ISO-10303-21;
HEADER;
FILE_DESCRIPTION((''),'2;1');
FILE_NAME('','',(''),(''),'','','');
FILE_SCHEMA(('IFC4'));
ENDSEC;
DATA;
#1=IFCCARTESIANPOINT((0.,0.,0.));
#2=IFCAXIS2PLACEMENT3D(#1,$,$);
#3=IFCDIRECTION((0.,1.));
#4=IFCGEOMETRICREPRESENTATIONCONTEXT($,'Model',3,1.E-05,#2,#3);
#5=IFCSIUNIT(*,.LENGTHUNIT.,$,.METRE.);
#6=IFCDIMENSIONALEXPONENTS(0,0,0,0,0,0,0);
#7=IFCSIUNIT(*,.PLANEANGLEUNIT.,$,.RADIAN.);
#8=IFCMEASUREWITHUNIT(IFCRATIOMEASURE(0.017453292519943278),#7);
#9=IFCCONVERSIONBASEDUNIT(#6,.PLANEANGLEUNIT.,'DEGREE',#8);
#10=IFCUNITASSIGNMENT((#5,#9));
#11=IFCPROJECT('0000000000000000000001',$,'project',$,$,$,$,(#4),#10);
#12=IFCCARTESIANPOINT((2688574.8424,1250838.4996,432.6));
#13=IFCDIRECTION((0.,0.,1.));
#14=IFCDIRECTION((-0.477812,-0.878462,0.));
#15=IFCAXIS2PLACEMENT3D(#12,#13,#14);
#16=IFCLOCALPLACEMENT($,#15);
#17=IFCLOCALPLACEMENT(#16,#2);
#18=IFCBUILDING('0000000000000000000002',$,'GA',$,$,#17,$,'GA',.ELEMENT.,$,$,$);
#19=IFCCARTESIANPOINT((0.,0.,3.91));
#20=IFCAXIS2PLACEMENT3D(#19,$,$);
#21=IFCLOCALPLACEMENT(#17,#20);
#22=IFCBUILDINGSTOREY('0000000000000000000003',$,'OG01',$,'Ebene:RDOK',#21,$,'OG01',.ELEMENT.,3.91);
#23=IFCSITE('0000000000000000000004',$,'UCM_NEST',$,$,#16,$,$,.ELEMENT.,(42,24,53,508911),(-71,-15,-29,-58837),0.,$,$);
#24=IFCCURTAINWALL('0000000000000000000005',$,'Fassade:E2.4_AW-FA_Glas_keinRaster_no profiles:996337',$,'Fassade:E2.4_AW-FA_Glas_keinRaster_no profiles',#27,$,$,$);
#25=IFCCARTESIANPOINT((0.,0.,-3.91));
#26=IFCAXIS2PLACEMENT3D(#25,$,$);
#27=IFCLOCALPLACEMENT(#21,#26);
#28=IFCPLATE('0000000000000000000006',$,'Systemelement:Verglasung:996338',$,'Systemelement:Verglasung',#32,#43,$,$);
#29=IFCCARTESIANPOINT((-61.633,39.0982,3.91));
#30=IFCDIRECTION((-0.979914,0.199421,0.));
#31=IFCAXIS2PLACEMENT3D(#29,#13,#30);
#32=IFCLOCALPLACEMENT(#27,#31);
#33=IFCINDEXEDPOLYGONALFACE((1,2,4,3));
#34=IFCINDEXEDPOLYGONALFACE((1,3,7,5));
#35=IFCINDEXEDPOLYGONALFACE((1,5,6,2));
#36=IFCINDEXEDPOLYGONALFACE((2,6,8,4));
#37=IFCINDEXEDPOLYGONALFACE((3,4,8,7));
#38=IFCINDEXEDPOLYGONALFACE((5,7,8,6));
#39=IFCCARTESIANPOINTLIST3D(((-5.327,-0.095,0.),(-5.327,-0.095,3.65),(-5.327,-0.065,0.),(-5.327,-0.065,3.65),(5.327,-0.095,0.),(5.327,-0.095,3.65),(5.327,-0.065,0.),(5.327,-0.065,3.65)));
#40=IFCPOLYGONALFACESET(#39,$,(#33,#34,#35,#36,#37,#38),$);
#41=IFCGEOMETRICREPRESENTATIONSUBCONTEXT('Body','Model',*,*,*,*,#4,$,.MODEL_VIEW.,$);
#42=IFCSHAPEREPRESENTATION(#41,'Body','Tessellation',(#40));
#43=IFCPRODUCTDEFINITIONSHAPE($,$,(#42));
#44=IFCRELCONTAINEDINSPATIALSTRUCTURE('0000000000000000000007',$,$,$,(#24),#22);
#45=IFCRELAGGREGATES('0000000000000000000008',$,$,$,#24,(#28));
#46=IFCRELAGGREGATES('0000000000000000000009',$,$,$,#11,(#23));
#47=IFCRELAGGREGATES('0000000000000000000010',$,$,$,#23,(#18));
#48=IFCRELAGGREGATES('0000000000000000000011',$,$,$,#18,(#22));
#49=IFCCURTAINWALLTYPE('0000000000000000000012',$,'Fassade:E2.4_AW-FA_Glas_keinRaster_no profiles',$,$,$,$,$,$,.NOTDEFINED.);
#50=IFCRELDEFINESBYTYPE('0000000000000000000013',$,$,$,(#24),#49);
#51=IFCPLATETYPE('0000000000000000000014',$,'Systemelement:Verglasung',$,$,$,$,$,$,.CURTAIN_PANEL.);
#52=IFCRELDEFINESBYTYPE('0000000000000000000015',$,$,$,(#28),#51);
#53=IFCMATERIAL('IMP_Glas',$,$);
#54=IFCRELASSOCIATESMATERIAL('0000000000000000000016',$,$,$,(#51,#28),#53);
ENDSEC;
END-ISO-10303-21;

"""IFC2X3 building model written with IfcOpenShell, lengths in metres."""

from ifc_helpers import new_model, entity, si_unit, converted_unit, direction, frame, frame_2d, origin, place, context, subcontext, project, spatial, rectangle, extrude, source, transform, mapped, material, type_object, type_shapes, element, aggregate, save


model = new_model("IFC2X3")

# Units and contexts
model_context = context("Model", 3, precision=1e-05, world=origin(), true_north=direction((0.0, 1.0)))
body_context = subcontext(model_context, "Body", "Model", "MODEL_VIEW")
ifc_project = project(units=[si_unit("LENGTHUNIT", "METRE"), converted_unit("PLANEANGLEUNIT", "DEGREE", entity("IfcRatioMeasure", 0.017453292519943278), si_unit("PLANEANGLEUNIT", "RADIAN"), dimensions=[0, 0, 0, 0, 0, 0, 0])], contexts=[model_context])

# Site, building, storey
site_placement = place(None, frame((2688574.8424, 1250838.4996, 432.6), z_axis=(0.0, 0.0, 1.0), x_axis=(-0.477812, -0.878462, 0.0)))
site = spatial("IfcSite", under=ifc_project, at=site_placement, Name="UCM_NEST", CompositionType="ELEMENT", RefLatitude=(42, 24, 53, 508911), RefLongitude=(-71, -15, -29, -58837), RefElevation=0.0)
building_placement = place(site_placement, origin())
building = spatial("IfcBuilding", under=site, at=building_placement, Name="GA", LongName="GA", CompositionType="ELEMENT")
storey_placement = place(building_placement, frame((0.0, 0.0, 3.91)))
storey = spatial("IfcBuildingStorey", under=building, at=storey_placement, Name="OG01", ObjectType="Ebene:RDOK", LongName="OG01", CompositionType="ELEMENT", Elevation=3.91)

# Curtain wall, plate
curtain_wall_type = type_object("IfcCurtainWallType", Name="Fassade:E2.4_AW-FA_Glas_keinRaster_no profiles", PredefinedType="NOTDEFINED")
curtain_wall_placement = place(storey_placement, frame((0.0, 0.0, -3.91)))
curtain_wall = element("IfcCurtainWall", 1, at=curtain_wall_placement, inside=storey, type_object=curtain_wall_type, Name="Fassade:E2.4_AW-FA_Glas_keinRaster_no profiles:996337", ObjectType="Fassade:E2.4_AW-FA_Glas_keinRaster_no profiles")
ifc_material_1 = material(Name="IMP_Glas")
plate_type = type_object("IfcPlateType", Name="Systemelement:Verglasung", PredefinedType="CURTAIN_PANEL", material=ifc_material_1)
shared_shape_1 = source(origin(), body_context, "Body", "SweptSolid", [
    extrude(rectangle(XDim=0.03, YDim=10.654, at=frame_2d((0.0, 0.0), x_axis=(1.0, 0.0))), frame((0.0, -0.08, 0.0), z_axis=(0.0, 0.0, 1.0), x_axis=(0.0, 1.0, 0.0)), (0.0, 0.0, 1.0), 3.65),
])
type_shapes(plate_type, [shared_shape_1])
plate_placement = place(curtain_wall_placement, frame((-61.633, 39.0982, 3.91), z_axis=(0.0, 0.0, 1.0), x_axis=(-0.979914, 0.199421, 0.0)))
plate = element("IfcPlate", 2, at=plate_placement, type_object=plate_type, material=ifc_material_1, Name="Systemelement:Verglasung:996338", ObjectType="Systemelement:Verglasung", context=body_context, shape_type="MappedRepresentation", body=[
    mapped(shared_shape_1, transform((0.0, 0.0, 0.0), scale=1.0)),
])
aggregate(curtain_wall, [plate])

save(model, "model.ifc")
